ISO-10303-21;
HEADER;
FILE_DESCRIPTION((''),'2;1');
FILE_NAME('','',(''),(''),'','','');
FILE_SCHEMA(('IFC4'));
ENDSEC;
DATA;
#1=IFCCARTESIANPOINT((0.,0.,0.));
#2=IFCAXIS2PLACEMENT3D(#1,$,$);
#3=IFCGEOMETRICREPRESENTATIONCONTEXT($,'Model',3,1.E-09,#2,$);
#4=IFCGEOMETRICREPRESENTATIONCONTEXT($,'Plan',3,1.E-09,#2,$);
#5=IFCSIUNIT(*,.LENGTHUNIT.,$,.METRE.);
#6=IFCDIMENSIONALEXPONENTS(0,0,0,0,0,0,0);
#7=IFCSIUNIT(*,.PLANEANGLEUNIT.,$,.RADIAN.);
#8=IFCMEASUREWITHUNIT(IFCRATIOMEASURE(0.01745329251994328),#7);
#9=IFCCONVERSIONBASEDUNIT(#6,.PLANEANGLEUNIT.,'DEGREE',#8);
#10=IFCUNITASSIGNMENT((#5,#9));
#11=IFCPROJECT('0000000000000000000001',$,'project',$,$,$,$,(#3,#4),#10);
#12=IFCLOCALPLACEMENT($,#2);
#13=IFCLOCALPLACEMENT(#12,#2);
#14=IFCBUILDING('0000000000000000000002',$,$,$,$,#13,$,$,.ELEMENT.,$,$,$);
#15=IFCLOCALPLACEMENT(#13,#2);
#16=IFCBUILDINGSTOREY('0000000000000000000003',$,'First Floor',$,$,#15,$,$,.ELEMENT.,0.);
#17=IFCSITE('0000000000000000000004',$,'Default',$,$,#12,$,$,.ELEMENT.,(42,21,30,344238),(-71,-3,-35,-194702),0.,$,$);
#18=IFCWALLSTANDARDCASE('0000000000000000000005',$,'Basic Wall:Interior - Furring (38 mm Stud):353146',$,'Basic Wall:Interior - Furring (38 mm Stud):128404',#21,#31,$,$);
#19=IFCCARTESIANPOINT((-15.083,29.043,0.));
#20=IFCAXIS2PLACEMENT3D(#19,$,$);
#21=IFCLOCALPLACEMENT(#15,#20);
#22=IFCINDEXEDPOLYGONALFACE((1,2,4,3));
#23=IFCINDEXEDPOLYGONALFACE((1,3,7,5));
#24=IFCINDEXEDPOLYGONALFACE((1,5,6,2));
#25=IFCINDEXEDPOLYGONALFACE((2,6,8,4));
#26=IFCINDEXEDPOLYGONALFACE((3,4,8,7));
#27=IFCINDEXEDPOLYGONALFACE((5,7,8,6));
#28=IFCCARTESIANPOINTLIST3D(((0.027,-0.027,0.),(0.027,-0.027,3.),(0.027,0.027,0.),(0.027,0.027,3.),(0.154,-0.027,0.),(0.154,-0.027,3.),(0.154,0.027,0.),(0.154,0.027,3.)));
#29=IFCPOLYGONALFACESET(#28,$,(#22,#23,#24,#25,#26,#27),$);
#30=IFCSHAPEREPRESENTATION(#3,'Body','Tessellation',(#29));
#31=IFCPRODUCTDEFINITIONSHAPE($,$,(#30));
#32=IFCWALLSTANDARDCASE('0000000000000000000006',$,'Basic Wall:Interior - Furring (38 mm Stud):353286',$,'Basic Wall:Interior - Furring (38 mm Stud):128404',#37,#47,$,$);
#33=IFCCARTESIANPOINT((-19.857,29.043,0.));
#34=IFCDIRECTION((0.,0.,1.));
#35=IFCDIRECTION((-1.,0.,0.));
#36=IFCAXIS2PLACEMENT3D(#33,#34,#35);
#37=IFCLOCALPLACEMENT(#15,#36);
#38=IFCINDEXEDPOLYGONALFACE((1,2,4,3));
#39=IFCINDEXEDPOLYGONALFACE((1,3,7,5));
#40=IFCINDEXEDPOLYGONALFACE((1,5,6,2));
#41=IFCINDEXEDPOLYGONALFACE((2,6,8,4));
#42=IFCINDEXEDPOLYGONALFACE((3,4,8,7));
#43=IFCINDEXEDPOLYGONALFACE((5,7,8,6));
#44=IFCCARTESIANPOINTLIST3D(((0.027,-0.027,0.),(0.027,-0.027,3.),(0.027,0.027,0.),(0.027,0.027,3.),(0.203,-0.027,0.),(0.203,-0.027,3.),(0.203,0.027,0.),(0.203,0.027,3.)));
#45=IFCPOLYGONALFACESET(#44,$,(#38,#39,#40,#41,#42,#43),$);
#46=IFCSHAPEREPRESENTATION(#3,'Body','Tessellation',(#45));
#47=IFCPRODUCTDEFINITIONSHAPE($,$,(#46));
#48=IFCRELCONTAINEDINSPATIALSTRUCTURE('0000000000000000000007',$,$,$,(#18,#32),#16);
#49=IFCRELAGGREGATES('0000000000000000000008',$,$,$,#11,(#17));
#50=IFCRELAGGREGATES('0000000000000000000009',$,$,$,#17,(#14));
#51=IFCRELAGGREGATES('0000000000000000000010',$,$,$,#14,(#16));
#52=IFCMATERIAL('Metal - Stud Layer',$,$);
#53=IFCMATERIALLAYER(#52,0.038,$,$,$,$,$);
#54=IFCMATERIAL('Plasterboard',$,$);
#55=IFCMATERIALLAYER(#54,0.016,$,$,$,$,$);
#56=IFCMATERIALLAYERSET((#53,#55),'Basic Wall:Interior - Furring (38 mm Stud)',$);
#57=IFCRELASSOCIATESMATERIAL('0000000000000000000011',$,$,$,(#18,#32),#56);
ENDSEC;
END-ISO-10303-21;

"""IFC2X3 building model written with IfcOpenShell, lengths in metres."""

from ifc_helpers import new_model, entity, si_unit, converted_unit, frame, frame_2d, origin, place, context, project, spatial, rectangle, extrude, material, layer, layer_set, layer_usage, element, save


model = new_model("IFC2X3")

# Units and contexts
model_context = context("Model", 3, precision=1e-09, world=origin())
plan_context = context("Plan", 3, precision=1e-09, world=origin())
ifc_project = project(units=[si_unit("LENGTHUNIT", "METRE"), converted_unit("PLANEANGLEUNIT", "DEGREE", entity("IfcRatioMeasure", 0.01745329251994328), si_unit("PLANEANGLEUNIT", "RADIAN"), dimensions=[0, 0, 0, 0, 0, 0, 0])], contexts=[model_context, plan_context])

# Site, building, storey
site_placement = place(None, origin())
site = spatial("IfcSite", under=ifc_project, at=site_placement, Name="Default", CompositionType="ELEMENT", RefLatitude=(42, 21, 30, 344238), RefLongitude=(-71, -3, -35, -194702), RefElevation=0.0)
building_placement = place(site_placement, origin())
building = spatial("IfcBuilding", under=site, at=building_placement, CompositionType="ELEMENT")
storey_placement = place(building_placement, origin())
storey = spatial("IfcBuildingStorey", under=building, at=storey_placement, Name="First Floor", CompositionType="ELEMENT", Elevation=0.0)

# Shared definitions
ifc_material_1 = material(Name="Metal - Stud Layer")

# Shared definitions
ifc_layer_1 = layer(ifc_material_1, 0.038)
ifc_material_2 = material(Name="Plasterboard")
ifc_layer_2 = layer(ifc_material_2, 0.016)
ifc_layer_set_1 = layer_set([ifc_layer_1, ifc_layer_2], Name="Basic Wall:Interior - Furring (38 mm Stud)")
ifc_layer_usage_1 = layer_usage(ifc_layer_set_1, "AXIS2", "POSITIVE", -0.027)

# Walls
ifc_layer_usage_2 = layer_usage(ifc_layer_set_1, "AXIS2", "NEGATIVE", 0.027)
wall_1_placement = place(storey_placement, frame((-15.083, 29.043, 0.0)))
element("IfcWallStandardCase", 1, at=wall_1_placement, inside=storey, material=ifc_layer_usage_1, Name="Basic Wall:Interior - Furring (38 mm Stud):353146", ObjectType="Basic Wall:Interior - Furring (38 mm Stud):128404", context=model_context, shape_type="SweptSolid", body=[
    extrude(rectangle(XDim=0.127, YDim=0.054, at=frame_2d((0.0905, 0.0), x_axis=(-1.0, 0.0))), origin(), (0.0, 0.0, 1.0), 3.0),
])
wall_2_placement = place(storey_placement, frame((-19.857, 29.043, 0.0), z_axis=(0.0, 0.0, 1.0), x_axis=(-1.0, 0.0, 0.0)))
element("IfcWallStandardCase", 2, at=wall_2_placement, inside=storey, material=ifc_layer_usage_2, Name="Basic Wall:Interior - Furring (38 mm Stud):353286", ObjectType="Basic Wall:Interior - Furring (38 mm Stud):128404", context=model_context, shape_type="SweptSolid", body=[
    extrude(rectangle(XDim=0.176, YDim=0.054, at=frame_2d((0.115, 0.0), x_axis=(-1.0, 0.0))), origin(), (0.0, 0.0, 1.0), 3.0),
])

save(model, "model.ifc")
